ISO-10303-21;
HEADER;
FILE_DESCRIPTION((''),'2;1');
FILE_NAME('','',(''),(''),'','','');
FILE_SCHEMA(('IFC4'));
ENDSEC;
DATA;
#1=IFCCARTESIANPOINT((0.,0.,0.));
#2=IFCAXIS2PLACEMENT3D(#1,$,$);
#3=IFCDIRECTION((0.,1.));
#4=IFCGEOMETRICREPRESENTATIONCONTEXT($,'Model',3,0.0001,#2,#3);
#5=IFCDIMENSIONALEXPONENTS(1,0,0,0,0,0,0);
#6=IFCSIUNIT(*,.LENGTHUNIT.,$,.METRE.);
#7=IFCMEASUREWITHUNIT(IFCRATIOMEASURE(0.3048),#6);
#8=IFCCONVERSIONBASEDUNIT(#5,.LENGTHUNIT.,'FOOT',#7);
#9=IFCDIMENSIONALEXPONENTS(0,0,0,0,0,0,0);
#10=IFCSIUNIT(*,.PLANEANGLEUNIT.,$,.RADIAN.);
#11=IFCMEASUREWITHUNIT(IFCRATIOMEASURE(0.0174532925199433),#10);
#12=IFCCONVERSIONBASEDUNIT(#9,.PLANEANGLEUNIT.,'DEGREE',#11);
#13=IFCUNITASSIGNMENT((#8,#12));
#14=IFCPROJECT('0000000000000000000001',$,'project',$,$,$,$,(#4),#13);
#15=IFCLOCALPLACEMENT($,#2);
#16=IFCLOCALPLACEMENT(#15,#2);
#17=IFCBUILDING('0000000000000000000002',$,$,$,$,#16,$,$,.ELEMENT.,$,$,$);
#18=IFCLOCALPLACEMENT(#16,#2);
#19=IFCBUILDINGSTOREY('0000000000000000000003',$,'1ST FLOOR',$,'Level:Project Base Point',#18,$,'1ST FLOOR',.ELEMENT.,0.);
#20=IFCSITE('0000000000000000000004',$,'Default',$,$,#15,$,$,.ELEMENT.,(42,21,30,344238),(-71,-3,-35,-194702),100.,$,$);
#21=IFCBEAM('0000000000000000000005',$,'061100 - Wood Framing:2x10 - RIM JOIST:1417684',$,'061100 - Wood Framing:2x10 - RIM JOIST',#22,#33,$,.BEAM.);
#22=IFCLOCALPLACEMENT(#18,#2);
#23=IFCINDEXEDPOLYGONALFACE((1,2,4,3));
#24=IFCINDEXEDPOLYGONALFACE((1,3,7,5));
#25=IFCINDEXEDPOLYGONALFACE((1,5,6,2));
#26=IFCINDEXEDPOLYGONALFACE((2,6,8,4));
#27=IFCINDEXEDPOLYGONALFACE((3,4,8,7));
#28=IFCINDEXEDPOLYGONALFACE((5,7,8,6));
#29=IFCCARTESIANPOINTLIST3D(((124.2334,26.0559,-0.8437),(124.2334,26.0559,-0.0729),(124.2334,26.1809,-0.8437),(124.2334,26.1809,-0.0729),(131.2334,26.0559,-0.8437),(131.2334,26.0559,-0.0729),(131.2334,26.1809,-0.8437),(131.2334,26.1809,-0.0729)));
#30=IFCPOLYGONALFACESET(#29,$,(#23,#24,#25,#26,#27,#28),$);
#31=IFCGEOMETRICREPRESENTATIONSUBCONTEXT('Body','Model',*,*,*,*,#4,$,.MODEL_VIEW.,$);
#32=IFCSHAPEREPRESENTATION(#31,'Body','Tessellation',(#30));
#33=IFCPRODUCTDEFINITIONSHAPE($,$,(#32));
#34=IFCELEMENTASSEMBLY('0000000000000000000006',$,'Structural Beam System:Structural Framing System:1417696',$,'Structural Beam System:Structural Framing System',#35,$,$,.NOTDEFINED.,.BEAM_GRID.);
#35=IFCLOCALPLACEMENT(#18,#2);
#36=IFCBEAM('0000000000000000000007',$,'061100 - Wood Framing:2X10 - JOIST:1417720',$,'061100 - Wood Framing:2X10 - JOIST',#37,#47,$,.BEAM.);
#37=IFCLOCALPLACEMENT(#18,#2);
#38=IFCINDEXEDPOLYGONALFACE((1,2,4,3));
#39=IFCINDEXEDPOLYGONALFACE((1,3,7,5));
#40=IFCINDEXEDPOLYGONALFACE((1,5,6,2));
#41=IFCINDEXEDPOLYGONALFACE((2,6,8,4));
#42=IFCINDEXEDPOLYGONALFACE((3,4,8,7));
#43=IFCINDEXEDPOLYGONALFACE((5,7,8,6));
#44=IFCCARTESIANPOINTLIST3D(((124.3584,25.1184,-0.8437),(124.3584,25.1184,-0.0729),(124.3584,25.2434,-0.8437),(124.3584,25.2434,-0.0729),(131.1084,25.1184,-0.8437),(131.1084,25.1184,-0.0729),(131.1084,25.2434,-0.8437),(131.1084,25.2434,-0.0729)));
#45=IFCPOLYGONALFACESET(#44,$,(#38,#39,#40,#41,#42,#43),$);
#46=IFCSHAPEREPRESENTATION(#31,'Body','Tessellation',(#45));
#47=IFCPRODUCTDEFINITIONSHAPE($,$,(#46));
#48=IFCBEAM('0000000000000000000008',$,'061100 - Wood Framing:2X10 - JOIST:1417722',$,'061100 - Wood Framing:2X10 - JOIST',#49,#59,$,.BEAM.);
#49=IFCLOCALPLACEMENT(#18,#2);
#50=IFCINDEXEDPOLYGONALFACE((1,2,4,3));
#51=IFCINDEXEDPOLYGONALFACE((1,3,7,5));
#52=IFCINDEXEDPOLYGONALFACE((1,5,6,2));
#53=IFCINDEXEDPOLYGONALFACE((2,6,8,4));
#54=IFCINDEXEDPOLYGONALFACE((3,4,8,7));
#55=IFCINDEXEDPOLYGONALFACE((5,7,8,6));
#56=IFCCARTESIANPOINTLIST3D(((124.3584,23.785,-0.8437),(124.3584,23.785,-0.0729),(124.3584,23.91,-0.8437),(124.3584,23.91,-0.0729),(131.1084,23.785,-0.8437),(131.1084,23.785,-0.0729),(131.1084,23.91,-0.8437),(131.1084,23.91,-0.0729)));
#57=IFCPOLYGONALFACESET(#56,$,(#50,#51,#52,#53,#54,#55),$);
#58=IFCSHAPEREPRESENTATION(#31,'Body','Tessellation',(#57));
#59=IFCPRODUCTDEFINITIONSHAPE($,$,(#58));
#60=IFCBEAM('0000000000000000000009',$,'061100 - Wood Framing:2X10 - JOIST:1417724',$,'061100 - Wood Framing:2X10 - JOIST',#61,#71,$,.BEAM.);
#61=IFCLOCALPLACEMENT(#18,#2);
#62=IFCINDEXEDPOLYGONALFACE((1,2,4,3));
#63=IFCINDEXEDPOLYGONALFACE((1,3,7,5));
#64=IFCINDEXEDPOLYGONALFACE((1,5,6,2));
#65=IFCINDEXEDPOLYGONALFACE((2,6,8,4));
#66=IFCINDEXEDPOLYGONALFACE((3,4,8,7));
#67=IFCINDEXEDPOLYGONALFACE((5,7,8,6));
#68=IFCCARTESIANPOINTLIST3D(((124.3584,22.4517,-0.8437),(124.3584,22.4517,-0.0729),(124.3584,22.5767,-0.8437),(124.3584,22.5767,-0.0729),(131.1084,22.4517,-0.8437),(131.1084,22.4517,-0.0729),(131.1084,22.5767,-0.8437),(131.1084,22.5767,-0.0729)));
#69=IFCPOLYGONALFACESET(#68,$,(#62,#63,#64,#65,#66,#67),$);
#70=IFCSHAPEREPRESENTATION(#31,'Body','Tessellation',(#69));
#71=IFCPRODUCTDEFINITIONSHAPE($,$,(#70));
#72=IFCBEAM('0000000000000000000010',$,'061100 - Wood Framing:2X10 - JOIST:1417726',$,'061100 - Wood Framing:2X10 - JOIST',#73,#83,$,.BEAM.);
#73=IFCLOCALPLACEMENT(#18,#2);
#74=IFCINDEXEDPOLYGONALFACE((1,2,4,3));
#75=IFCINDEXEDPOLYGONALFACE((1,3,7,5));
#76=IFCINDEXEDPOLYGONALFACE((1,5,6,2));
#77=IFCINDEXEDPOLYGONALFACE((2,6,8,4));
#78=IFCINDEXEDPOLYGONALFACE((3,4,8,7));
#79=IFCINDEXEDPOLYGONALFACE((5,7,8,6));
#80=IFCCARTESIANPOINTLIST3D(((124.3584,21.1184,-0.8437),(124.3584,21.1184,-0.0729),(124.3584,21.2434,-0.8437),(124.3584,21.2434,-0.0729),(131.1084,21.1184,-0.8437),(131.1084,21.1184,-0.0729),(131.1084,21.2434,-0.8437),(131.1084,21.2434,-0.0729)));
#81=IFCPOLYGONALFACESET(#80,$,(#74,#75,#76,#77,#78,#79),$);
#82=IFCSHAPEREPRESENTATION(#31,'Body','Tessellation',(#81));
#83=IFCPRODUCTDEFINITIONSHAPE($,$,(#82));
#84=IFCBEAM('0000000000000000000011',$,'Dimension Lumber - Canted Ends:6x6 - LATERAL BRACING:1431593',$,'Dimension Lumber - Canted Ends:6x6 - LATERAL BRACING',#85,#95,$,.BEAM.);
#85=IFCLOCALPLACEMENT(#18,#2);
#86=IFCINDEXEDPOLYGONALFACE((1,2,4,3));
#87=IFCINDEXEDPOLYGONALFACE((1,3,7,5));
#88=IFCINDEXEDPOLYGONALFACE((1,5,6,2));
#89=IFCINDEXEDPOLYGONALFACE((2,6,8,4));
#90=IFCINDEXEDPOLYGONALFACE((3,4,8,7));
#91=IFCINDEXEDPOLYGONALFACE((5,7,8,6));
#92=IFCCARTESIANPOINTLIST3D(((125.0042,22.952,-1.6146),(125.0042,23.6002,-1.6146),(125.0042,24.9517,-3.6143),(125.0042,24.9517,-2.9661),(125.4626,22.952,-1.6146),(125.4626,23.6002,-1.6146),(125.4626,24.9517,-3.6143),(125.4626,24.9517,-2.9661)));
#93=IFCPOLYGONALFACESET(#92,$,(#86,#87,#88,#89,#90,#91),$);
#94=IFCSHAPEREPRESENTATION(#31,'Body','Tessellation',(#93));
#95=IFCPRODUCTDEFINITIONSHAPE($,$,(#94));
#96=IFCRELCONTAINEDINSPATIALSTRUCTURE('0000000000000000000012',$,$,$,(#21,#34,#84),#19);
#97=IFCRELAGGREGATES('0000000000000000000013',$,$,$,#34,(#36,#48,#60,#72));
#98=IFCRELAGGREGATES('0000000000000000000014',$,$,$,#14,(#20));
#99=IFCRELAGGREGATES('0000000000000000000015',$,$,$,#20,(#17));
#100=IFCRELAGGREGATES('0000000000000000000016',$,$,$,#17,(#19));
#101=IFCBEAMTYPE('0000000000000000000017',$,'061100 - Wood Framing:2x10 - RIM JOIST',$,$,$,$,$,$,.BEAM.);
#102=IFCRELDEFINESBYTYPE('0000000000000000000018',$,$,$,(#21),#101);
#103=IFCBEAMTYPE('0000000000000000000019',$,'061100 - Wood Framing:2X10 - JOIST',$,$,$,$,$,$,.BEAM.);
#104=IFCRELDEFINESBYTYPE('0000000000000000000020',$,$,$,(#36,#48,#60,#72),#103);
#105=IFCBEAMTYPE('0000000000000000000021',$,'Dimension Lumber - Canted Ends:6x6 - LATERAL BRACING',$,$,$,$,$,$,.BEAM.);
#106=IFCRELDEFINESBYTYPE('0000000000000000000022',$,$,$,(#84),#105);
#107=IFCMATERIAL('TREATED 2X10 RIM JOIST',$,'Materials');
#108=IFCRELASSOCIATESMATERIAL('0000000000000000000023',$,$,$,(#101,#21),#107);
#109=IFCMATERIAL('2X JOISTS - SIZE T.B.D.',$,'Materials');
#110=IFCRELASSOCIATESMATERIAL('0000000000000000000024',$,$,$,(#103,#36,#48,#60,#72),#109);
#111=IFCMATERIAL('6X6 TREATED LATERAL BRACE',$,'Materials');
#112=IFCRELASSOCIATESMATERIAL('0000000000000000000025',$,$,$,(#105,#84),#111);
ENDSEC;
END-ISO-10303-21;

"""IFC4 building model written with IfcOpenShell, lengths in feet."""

from ifc_helpers import new_model, entity, si_unit, converted_unit, direction, frame, frame_2d, origin, origin_2d_with_axis, place, context, subcontext, project, spatial, rectangle, extrude, clip, halfspace, source, transform, mapped, material, material_profile, profile_set, profile_usage, type_object, type_shapes, element, aggregate, save


model = new_model("IFC4")

# Units and contexts
model_context = context("Model", 3, precision=0.0001, world=origin(), true_north=direction((0.0, 1.0)))
body_context = subcontext(model_context, "Body", "Model", "MODEL_VIEW")
ifc_project = project(units=[converted_unit("LENGTHUNIT", "FOOT", entity("IfcRatioMeasure", 0.3048), si_unit("LENGTHUNIT", "METRE"), dimensions=[1, 0, 0, 0, 0, 0, 0]), converted_unit("PLANEANGLEUNIT", "DEGREE", entity("IfcRatioMeasure", 0.0174532925199433), si_unit("PLANEANGLEUNIT", "RADIAN"), dimensions=[0, 0, 0, 0, 0, 0, 0])], contexts=[model_context])

# Site, building, storey
site_placement = place(None, origin())
site = spatial("IfcSite", under=ifc_project, at=site_placement, Name="Default", CompositionType="ELEMENT", RefLatitude=(42, 21, 30, 344238), RefLongitude=(-71, -3, -35, -194702), RefElevation=100.0)
building_placement = place(site_placement, origin())
building = spatial("IfcBuilding", under=site, at=building_placement, CompositionType="ELEMENT")
storey_placement = place(building_placement, origin())
storey = spatial("IfcBuildingStorey", under=building, at=storey_placement, Name="1ST FLOOR", ObjectType="Level:Project Base Point", LongName="1ST FLOOR", CompositionType="ELEMENT", Elevation=0.0)

# Beam
ifc_material_1 = material(Name="TREATED 2X10 RIM JOIST", Category="Materials")
ifc_material_profile_1 = material_profile(ifc_material_1, rectangle(XDim=0.7708, YDim=0.125, at=origin_2d_with_axis()), Name="2x10 - RIM JOIST")
ifc_profile_set_1 = profile_set([ifc_material_profile_1], Name="2x10 - RIM JOIST")
ifc_profile_usage_1 = profile_usage(ifc_profile_set_1, cardinal=8)
beam_type_1 = type_object("IfcBeamType", Name="061100 - Wood Framing:2x10 - RIM JOIST", PredefinedType="BEAM", material=ifc_profile_set_1)
shared_shape_1 = source(origin(), body_context, "Body", "SweptSolid", [
    extrude(rectangle(XDim=0.7708, YDim=0.125, at=origin_2d_with_axis()), frame((-3.5, 0.0, 0.0), z_axis=(1.0, 0.0, 0.0), x_axis=(0.0, 0.0, -1.0)), (0.0, 0.0, 1.0), 7.0),
])
type_shapes(beam_type_1, [shared_shape_1])
beam_1_placement = place(storey_placement, frame((127.7334, 26.1184, -0.4583), z_axis=(0.0, 0.0, 1.0), x_axis=(-1.0, 0.0, 0.0)))
element("IfcBeam", 1, at=beam_1_placement, inside=storey, type_object=beam_type_1, material=ifc_profile_usage_1, Name="061100 - Wood Framing:2x10 - RIM JOIST:1417684", ObjectType="061100 - Wood Framing:2x10 - RIM JOIST", PredefinedType="BEAM", context=body_context, shape_type="MappedRepresentation", body=[
    mapped(shared_shape_1, transform((0.0, 0.0, 0.0), scale=1.0)),
])

# Element assembly, beams
assembly_placement = place(storey_placement, origin())
assembly = element("IfcElementAssembly", 2, at=assembly_placement, inside=storey, Name="Structural Beam System:Structural Framing System:1417696", ObjectType="Structural Beam System:Structural Framing System", AssemblyPlace="NOTDEFINED", PredefinedType="BEAM_GRID")
ifc_material_2 = material(Name="2X JOISTS - SIZE T.B.D.", Category="Materials")
ifc_material_profile_2 = material_profile(ifc_material_2, rectangle(XDim=0.7708, YDim=0.125, at=frame_2d((0.0, 0.0), x_axis=(1.0, 0.0))), Name="2X10 - JOIST")
ifc_profile_set_2 = profile_set([ifc_material_profile_2], Name="2X10 - JOIST")
ifc_profile_usage_2 = profile_usage(ifc_profile_set_2, cardinal=8)
beam_type_2 = type_object("IfcBeamType", Name="061100 - Wood Framing:2X10 - JOIST", PredefinedType="BEAM", material=ifc_profile_set_2)
shared_shape_2 = source(origin(), body_context, "Body", "SweptSolid", [
    extrude(rectangle(XDim=0.7708, YDim=0.125, at=frame_2d((0.0, 0.0), x_axis=(1.0, 0.0))), frame((-3.375, 0.0, 0.0), z_axis=(1.0, 0.0, 0.0), x_axis=(0.0, 0.0, -1.0)), (0.0, 0.0, 1.0), 6.75),
])
type_shapes(beam_type_2, [shared_shape_2])
beam_2_placement = place(assembly_placement, frame((127.7334, 25.1809, -0.4583)))
beam_2 = element("IfcBeam", 3, at=beam_2_placement, type_object=beam_type_2, material=ifc_profile_usage_2, Name="061100 - Wood Framing:2X10 - JOIST:1417720", ObjectType="061100 - Wood Framing:2X10 - JOIST", PredefinedType="BEAM", context=body_context, shape_type="MappedRepresentation", body=[
    mapped(shared_shape_2, transform((0.0, 0.0, 0.0), scale=1.0)),
])
ifc_profile_usage_3 = profile_usage(ifc_profile_set_2, cardinal=8)
beam_3_placement = place(assembly_placement, frame((127.7334, 23.8475, -0.4583)))
beam_3 = element("IfcBeam", 4, at=beam_3_placement, type_object=beam_type_2, material=ifc_profile_usage_3, Name="061100 - Wood Framing:2X10 - JOIST:1417722", ObjectType="061100 - Wood Framing:2X10 - JOIST", PredefinedType="BEAM", context=body_context, shape_type="MappedRepresentation", body=[
    mapped(shared_shape_2, transform((0.0, 0.0, 0.0), scale=1.0)),
])
ifc_profile_usage_4 = profile_usage(ifc_profile_set_2, cardinal=8)
beam_4_placement = place(assembly_placement, frame((127.7334, 22.5142, -0.4583)))
beam_4 = element("IfcBeam", 5, at=beam_4_placement, type_object=beam_type_2, material=ifc_profile_usage_4, Name="061100 - Wood Framing:2X10 - JOIST:1417724", ObjectType="061100 - Wood Framing:2X10 - JOIST", PredefinedType="BEAM", context=body_context, shape_type="MappedRepresentation", body=[
    mapped(shared_shape_2, transform((0.0, 0.0, 0.0), scale=1.0)),
])
ifc_profile_usage_5 = profile_usage(ifc_profile_set_2, cardinal=8)
beam_5_placement = place(assembly_placement, frame((127.7334, 21.1809, -0.4583)))
beam_5 = element("IfcBeam", 6, at=beam_5_placement, type_object=beam_type_2, material=ifc_profile_usage_5, Name="061100 - Wood Framing:2X10 - JOIST:1417726", ObjectType="061100 - Wood Framing:2X10 - JOIST", PredefinedType="BEAM", context=body_context, shape_type="MappedRepresentation", body=[
    mapped(shared_shape_2, transform((0.0, 0.0, 0.0), scale=1.0)),
])
aggregate(assembly, [beam_2, beam_3, beam_4, beam_5])

# Beam
ifc_material_3 = material(Name="6X6 TREATED LATERAL BRACE", Category="Materials")
ifc_material_profile_3 = material_profile(ifc_material_3, rectangle(XDim=0.4583, YDim=0.4583, at=origin_2d_with_axis()), Name="6x6 - LATERAL BRACING")
ifc_profile_set_3 = profile_set([ifc_material_profile_3], Name="6x6 - LATERAL BRACING")
ifc_profile_usage_6 = profile_usage(ifc_profile_set_3, cardinal=2)
beam_type_3 = type_object("IfcBeamType", Name="Dimension Lumber - Canted Ends:6x6 - LATERAL BRACING", PredefinedType="BEAM", material=ifc_profile_set_3)
shared_shape_3 = source(origin(), body_context, "Body", "Clipping", [
    clip(clip(extrude(rectangle(XDim=0.4583, YDim=0.4583, at=origin_2d_with_axis()), frame((-1.414, 0.0, 0.0), z_axis=(1.0, 0.0, 0.0), x_axis=(0.0, 0.0, -1.0)), (0.0, 0.0, 1.0), 2.828), halfspace(frame((-0.9557, 0.2292, 0.2292), z_axis=(-0.707107, 0.0, 0.707107), x_axis=(0.0, -1.0, 0.0)), False)), halfspace(frame((1.414, 0.2292, -0.2292), z_axis=(0.707107, 0.0, 0.707107), x_axis=(0.0, -1.0, 0.0)), False)),
])
type_shapes(beam_type_3, [shared_shape_3])
beam_6_placement = place(storey_placement, frame((125.2334, 24.1139, -2.4524), z_axis=(0.0, 0.707107, 0.707107), x_axis=(0.0, 0.707107, -0.707107)))
element("IfcBeam", 7, at=beam_6_placement, inside=storey, type_object=beam_type_3, material=ifc_profile_usage_6, Name="Dimension Lumber - Canted Ends:6x6 - LATERAL BRACING:1431593", ObjectType="Dimension Lumber - Canted Ends:6x6 - LATERAL BRACING", PredefinedType="BEAM", context=body_context, shape_type="MappedRepresentation", body=[
    mapped(shared_shape_3, transform((0.0, 0.0, 0.0), scale=1.0)),
])

save(model, "model.ifc")
